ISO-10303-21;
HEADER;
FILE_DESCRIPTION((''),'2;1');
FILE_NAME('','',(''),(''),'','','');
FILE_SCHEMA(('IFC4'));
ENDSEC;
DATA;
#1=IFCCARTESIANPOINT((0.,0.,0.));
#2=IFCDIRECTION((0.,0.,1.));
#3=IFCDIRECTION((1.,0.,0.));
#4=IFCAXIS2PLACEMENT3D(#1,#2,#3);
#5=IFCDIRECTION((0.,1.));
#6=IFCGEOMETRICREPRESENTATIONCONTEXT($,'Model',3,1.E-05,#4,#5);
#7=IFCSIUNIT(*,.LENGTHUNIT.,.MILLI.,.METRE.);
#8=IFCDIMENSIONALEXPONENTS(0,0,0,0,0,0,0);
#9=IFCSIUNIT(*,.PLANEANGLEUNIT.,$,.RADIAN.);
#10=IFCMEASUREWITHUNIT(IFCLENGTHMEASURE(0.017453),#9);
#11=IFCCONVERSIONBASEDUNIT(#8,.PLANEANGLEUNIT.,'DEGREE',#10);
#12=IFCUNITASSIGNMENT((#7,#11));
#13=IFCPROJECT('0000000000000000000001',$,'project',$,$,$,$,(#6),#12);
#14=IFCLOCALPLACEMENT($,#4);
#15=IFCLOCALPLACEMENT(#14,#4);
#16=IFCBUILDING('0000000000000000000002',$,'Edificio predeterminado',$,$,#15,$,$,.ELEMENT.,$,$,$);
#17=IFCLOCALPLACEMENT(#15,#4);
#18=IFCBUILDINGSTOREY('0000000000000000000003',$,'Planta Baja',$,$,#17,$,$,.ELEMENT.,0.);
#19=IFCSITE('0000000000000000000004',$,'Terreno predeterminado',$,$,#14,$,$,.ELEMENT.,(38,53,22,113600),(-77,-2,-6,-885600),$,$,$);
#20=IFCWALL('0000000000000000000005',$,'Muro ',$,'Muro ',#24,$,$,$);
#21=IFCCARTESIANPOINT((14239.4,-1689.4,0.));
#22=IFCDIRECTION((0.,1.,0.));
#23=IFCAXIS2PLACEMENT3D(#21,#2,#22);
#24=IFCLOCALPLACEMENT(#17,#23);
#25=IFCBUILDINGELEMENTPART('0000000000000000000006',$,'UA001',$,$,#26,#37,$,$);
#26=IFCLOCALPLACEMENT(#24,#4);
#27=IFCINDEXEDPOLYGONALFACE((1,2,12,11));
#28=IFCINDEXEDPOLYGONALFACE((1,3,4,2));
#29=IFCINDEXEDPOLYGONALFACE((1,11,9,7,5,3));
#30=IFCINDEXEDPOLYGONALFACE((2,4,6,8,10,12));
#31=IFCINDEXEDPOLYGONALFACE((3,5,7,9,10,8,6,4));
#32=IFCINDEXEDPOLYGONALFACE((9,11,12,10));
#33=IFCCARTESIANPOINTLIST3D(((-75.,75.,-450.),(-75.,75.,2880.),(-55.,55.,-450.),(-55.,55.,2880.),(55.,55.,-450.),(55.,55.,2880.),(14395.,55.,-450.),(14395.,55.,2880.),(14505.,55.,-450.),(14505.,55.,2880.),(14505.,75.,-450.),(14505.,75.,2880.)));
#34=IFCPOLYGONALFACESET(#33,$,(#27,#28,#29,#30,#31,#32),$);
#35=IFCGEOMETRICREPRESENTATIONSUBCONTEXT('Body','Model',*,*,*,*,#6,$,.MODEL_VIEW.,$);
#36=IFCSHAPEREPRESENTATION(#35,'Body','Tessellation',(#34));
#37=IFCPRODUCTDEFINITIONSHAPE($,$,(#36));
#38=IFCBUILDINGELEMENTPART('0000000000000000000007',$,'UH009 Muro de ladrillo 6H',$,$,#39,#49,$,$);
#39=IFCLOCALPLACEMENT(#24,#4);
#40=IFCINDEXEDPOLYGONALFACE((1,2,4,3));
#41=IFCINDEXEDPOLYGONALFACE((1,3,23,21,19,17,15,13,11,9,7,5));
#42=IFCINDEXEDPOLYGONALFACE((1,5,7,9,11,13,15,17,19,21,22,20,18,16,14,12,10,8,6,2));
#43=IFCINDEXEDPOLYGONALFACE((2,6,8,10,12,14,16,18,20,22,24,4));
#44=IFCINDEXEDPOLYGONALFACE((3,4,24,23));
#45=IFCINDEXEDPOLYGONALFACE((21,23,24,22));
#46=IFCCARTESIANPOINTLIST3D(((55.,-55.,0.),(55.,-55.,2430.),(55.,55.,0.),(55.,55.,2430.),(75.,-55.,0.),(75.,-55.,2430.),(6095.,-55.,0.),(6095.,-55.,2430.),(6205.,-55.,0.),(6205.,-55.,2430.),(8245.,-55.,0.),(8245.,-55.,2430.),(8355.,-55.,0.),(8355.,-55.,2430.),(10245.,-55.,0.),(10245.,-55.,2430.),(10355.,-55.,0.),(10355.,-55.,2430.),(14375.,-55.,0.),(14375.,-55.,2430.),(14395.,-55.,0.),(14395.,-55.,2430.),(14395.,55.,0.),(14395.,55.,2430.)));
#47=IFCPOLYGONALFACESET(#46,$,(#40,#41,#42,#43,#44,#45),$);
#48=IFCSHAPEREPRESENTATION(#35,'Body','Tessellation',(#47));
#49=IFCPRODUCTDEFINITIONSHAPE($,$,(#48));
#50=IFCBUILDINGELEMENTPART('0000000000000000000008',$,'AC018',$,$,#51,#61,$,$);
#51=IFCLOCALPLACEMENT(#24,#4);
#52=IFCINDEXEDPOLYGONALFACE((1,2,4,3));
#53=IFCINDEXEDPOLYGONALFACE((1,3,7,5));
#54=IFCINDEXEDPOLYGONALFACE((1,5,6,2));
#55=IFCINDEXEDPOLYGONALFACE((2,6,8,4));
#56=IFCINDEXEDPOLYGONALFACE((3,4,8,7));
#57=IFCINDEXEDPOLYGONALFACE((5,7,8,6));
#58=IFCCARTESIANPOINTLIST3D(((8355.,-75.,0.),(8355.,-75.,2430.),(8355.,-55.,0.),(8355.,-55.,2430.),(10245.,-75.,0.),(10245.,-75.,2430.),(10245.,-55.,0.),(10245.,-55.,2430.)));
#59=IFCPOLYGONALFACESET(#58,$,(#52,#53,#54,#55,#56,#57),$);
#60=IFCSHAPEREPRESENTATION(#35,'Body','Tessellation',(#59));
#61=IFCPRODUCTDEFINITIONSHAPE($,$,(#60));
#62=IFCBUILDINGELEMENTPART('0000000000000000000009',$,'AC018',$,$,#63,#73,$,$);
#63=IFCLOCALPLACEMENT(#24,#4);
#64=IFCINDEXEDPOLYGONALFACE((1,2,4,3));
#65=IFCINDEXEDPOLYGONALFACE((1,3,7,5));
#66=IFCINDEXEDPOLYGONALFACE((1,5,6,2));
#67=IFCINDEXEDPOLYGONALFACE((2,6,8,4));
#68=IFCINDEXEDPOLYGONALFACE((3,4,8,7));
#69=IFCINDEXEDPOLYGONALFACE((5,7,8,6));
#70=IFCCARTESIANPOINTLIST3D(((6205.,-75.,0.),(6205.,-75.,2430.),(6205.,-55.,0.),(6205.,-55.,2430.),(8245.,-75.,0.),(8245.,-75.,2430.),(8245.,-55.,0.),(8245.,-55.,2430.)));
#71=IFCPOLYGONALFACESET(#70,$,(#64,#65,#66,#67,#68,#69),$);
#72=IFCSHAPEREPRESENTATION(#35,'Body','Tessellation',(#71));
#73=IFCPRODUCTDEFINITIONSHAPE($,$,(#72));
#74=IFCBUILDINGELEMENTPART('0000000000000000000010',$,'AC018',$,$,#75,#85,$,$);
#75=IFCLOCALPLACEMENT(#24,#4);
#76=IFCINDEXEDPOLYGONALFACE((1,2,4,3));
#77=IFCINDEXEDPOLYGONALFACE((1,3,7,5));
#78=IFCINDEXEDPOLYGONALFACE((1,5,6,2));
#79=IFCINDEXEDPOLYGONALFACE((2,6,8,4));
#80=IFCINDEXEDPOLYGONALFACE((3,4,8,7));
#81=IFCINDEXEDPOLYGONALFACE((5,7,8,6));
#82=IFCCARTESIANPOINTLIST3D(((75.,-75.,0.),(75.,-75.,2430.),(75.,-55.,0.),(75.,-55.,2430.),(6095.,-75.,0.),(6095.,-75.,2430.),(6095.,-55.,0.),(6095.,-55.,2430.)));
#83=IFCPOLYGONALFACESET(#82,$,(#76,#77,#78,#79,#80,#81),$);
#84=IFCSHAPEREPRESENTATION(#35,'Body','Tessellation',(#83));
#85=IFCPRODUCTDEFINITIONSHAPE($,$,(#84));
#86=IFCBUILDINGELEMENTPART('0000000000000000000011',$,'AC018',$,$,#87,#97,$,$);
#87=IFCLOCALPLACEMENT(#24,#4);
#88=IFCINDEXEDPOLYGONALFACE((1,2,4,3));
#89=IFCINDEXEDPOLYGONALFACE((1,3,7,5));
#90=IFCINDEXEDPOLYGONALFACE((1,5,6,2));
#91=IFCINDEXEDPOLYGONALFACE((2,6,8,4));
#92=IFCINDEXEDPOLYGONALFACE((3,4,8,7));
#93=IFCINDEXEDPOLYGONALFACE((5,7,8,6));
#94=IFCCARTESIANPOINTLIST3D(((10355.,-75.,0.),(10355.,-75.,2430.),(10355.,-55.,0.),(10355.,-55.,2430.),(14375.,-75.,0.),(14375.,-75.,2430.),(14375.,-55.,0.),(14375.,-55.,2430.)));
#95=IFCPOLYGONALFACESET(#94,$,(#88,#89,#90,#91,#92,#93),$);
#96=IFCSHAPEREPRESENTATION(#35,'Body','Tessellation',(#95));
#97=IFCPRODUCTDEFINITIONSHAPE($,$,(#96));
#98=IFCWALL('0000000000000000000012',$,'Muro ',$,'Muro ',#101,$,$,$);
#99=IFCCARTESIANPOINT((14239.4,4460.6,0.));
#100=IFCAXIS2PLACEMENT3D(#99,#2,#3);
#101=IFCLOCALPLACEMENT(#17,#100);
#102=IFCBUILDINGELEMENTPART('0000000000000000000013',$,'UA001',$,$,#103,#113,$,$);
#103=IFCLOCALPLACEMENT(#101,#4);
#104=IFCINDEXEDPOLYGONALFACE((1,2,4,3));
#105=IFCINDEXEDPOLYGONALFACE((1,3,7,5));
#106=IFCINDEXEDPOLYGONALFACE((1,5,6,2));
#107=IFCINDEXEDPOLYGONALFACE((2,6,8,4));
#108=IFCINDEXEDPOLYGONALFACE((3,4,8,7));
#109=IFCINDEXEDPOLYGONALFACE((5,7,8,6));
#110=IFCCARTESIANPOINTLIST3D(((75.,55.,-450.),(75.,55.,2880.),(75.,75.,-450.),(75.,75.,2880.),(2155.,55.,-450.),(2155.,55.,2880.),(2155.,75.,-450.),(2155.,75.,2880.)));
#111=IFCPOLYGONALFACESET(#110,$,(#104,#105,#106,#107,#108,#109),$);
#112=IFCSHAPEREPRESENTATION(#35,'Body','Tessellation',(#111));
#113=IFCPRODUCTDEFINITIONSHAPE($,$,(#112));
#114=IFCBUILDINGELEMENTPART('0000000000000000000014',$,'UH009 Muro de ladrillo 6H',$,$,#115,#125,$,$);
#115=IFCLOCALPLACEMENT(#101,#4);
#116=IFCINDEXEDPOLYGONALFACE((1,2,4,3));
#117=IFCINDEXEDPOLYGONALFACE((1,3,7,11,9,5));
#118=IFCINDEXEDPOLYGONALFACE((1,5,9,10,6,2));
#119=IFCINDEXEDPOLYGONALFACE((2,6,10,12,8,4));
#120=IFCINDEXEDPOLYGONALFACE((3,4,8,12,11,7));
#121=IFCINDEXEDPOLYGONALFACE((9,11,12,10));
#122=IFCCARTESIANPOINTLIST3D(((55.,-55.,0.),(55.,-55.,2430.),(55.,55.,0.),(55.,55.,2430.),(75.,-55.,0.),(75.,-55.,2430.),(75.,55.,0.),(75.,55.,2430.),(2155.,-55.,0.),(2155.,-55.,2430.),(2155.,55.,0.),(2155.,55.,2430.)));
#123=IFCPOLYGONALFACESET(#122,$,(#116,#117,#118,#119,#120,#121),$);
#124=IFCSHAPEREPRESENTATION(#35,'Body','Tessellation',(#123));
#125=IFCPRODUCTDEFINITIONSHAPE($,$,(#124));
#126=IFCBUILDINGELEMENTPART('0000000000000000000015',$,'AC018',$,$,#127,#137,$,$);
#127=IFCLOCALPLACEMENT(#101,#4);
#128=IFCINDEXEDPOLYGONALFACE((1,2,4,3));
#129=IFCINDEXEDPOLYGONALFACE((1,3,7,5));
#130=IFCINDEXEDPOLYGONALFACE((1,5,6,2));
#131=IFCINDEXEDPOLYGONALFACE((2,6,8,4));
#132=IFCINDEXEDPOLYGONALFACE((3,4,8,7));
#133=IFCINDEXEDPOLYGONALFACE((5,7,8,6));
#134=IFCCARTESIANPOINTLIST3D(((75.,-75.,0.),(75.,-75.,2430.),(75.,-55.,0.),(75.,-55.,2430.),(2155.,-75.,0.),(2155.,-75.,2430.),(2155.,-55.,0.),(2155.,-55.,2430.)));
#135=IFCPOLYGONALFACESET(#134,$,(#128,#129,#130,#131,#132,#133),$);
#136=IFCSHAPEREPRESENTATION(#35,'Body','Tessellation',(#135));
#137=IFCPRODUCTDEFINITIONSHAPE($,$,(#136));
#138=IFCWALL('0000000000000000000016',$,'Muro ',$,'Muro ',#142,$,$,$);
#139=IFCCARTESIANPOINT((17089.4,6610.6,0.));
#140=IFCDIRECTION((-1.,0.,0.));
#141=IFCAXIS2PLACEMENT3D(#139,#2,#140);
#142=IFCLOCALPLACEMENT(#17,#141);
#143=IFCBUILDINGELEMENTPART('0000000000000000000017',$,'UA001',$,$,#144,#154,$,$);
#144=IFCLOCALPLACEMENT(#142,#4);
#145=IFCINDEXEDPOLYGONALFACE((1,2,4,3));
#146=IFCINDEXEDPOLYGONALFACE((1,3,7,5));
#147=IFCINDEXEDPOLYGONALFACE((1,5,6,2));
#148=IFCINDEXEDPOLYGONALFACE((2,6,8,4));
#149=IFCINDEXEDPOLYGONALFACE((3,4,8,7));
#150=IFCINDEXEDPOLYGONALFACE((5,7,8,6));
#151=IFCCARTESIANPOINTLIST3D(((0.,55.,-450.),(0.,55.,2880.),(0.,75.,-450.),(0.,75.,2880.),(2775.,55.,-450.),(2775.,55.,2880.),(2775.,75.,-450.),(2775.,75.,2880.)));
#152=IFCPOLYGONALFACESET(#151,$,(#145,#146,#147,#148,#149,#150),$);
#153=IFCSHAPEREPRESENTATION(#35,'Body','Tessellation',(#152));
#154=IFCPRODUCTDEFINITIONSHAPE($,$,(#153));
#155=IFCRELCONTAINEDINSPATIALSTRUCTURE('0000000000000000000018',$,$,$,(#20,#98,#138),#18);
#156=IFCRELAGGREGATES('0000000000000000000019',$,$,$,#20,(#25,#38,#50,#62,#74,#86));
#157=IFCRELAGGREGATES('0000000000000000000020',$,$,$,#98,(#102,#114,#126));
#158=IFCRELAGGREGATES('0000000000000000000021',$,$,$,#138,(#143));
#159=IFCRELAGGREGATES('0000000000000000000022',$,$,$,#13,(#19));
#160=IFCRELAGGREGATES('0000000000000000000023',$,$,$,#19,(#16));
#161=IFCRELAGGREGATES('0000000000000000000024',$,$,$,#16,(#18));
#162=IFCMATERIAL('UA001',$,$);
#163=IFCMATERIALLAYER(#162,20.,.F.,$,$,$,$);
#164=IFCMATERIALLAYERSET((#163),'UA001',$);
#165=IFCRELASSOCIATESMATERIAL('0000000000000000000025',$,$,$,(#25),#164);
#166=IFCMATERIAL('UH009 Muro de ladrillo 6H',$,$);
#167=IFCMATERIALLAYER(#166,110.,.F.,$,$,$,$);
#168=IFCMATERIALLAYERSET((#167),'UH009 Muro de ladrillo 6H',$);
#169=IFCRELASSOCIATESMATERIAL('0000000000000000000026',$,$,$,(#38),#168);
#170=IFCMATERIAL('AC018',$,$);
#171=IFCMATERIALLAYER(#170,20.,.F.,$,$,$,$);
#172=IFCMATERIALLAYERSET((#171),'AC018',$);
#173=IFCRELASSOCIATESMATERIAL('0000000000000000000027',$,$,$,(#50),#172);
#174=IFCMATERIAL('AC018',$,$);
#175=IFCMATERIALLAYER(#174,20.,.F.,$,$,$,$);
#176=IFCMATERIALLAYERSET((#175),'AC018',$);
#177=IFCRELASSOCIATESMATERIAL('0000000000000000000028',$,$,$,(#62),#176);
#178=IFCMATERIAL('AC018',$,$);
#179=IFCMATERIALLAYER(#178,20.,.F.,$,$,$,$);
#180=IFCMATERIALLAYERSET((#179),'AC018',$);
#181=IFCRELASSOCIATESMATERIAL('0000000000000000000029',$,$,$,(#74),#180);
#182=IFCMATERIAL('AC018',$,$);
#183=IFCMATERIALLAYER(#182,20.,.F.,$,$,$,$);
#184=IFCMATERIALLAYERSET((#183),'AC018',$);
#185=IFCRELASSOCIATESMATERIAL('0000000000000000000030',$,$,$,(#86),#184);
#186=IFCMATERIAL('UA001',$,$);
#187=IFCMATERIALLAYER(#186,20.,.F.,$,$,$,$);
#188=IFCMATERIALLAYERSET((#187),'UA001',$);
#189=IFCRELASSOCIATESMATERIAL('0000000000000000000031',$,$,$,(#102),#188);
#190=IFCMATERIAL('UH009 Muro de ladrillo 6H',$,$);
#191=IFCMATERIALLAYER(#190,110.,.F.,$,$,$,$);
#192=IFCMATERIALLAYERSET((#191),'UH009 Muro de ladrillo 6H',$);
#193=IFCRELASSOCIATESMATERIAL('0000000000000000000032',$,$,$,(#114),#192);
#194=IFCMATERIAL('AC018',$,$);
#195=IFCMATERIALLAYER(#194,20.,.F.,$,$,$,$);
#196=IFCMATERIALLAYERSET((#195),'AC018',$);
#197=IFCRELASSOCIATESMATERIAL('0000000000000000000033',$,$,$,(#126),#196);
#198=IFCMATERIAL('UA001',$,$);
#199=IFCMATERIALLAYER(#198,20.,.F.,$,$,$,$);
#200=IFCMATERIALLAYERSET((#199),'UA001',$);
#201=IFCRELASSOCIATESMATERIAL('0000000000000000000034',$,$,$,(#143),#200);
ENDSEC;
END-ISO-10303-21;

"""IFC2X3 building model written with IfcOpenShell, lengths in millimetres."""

from ifc_helpers import new_model, entity, si_unit, converted_unit, direction, frame, origin_with_axes, place, context, subcontext, project, spatial, polyline, outline, extrude, material, layer, layer_set, layer_usage, element, aggregate, save


model = new_model("IFC2X3")

# Units and contexts
model_context = context("Model", 3, precision=1e-05, world=origin_with_axes(), true_north=direction((0.0, 1.0)))
body_context = subcontext(model_context, "Body", "Model", "MODEL_VIEW")
ifc_project = project(units=[si_unit("LENGTHUNIT", "METRE", prefix="MILLI"), converted_unit("PLANEANGLEUNIT", "DEGREE", entity("IfcLengthMeasure", 0.017453), si_unit("PLANEANGLEUNIT", "RADIAN"), dimensions=[0, 0, 0, 0, 0, 0, 0])], contexts=[model_context])

# Site, building, storey
site_placement = place(None, origin_with_axes())
site = spatial("IfcSite", under=ifc_project, at=site_placement, Name="Terreno predeterminado", CompositionType="ELEMENT", RefLatitude=(38, 53, 22, 113600), RefLongitude=(-77, -2, -6, -885600))
building_placement = place(site_placement, origin_with_axes())
building = spatial("IfcBuilding", under=site, at=building_placement, Name="Edificio predeterminado", CompositionType="ELEMENT")
storey_placement = place(building_placement, origin_with_axes())
storey = spatial("IfcBuildingStorey", under=building, at=storey_placement, Name="Planta Baja", CompositionType="ELEMENT", Elevation=0.0)

# Walls, building element parts
wall_1_placement = place(storey_placement, frame((14239.4, -1689.4, 0.0), z_axis=(0.0, 0.0, 1.0), x_axis=(0.0, 1.0, 0.0)))
wall_1 = element("IfcWall", 1, at=wall_1_placement, inside=storey, Name="Muro ", ObjectType="Muro ")
ifc_material_1 = material(Name="UA001")
ifc_layer_1 = layer(ifc_material_1, 20.0, ventilated=False)
ifc_layer_set_1 = layer_set([ifc_layer_1], Name="UA001")
ifc_layer_usage_1 = layer_usage(ifc_layer_set_1, "AXIS2", "NEGATIVE", -75.0)
building_element_part_1_placement = place(wall_1_placement, origin_with_axes())
building_element_part_1 = element("IfcBuildingElementPart", 2, at=building_element_part_1_placement, material=ifc_layer_usage_1, Name="UA001", context=body_context, shape_type="SweptSolid", body=[
    extrude(outline(polyline([(14505.0, 75.0), (14505.0, 55.0), (14395.0, 55.0), (55.0, 55.0), (-55.0, 55.0), (-75.0, 75.0), (14505.0, 75.0)])), frame((0.0, 0.0, -450.0), z_axis=(0.0, 0.0, 1.0), x_axis=(1.0, 0.0, 0.0)), (0.0, 0.0, 1.0), 3330.0),
])
ifc_material_2 = material(Name="UH009 Muro de ladrillo 6H")
ifc_layer_2 = layer(ifc_material_2, 110.0, ventilated=False)
ifc_layer_set_2 = layer_set([ifc_layer_2], Name="UH009 Muro de ladrillo 6H")
ifc_layer_usage_2 = layer_usage(ifc_layer_set_2, "AXIS2", "NEGATIVE", -55.0)
building_element_part_2_placement = place(wall_1_placement, origin_with_axes())
building_element_part_2 = element("IfcBuildingElementPart", 3, at=building_element_part_2_placement, material=ifc_layer_usage_2, Name="UH009 Muro de ladrillo 6H", context=body_context, shape_type="SweptSolid", body=[
    extrude(outline(polyline([(14395.0, 55.0), (14395.0, -55.0), (14375.0, -55.0), (10355.0, -55.0), (10245.0, -55.0), (8355.0, -55.0), (8245.0, -55.0), (6205.0, -55.0), (6095.0, -55.0), (75.0, -55.0), (55.0, -55.0), (55.0, 55.0), (14395.0, 55.0)])), origin_with_axes(), (0.0, 0.0, 1.0), 2430.0),
])
ifc_material_3 = material(Name="AC018")
ifc_layer_3 = layer(ifc_material_3, 20.0, ventilated=False)
ifc_layer_set_3 = layer_set([ifc_layer_3], Name="AC018")
ifc_layer_usage_3 = layer_usage(ifc_layer_set_3, "AXIS2", "NEGATIVE", 55.0)
building_element_part_3_placement = place(wall_1_placement, origin_with_axes())
building_element_part_3 = element("IfcBuildingElementPart", 4, at=building_element_part_3_placement, material=ifc_layer_usage_3, Name="AC018", context=body_context, shape_type="SweptSolid", body=[
    extrude(outline(polyline([(8355.0, -55.0), (10245.0, -55.0), (10245.0, -75.0), (8355.0, -75.0), (8355.0, -55.0)])), origin_with_axes(), (0.0, 0.0, 1.0), 2430.0),
])
ifc_material_4 = material(Name="AC018")
ifc_layer_4 = layer(ifc_material_4, 20.0, ventilated=False)
ifc_layer_set_4 = layer_set([ifc_layer_4], Name="AC018")
ifc_layer_usage_4 = layer_usage(ifc_layer_set_4, "AXIS2", "NEGATIVE", 55.0)
building_element_part_4_placement = place(wall_1_placement, origin_with_axes())
building_element_part_4 = element("IfcBuildingElementPart", 5, at=building_element_part_4_placement, material=ifc_layer_usage_4, Name="AC018", context=body_context, shape_type="SweptSolid", body=[
    extrude(outline(polyline([(8245.0, -55.0), (8245.0, -75.0), (6205.0, -75.0), (6205.0, -55.0), (8245.0, -55.0)])), origin_with_axes(), (0.0, 0.0, 1.0), 2430.0),
])
ifc_material_5 = material(Name="AC018")
ifc_layer_5 = layer(ifc_material_5, 20.0, ventilated=False)
ifc_layer_set_5 = layer_set([ifc_layer_5], Name="AC018")
ifc_layer_usage_5 = layer_usage(ifc_layer_set_5, "AXIS2", "NEGATIVE", 55.0)
building_element_part_5_placement = place(wall_1_placement, origin_with_axes())
building_element_part_5 = element("IfcBuildingElementPart", 6, at=building_element_part_5_placement, material=ifc_layer_usage_5, Name="AC018", context=body_context, shape_type="SweptSolid", body=[
    extrude(outline(polyline([(6095.0, -55.0), (6095.0, -75.0), (75.0, -75.0), (75.0, -55.0), (6095.0, -55.0)])), origin_with_axes(), (0.0, 0.0, 1.0), 2430.0),
])
ifc_material_6 = material(Name="AC018")
ifc_layer_6 = layer(ifc_material_6, 20.0, ventilated=False)
ifc_layer_set_6 = layer_set([ifc_layer_6], Name="AC018")
ifc_layer_usage_6 = layer_usage(ifc_layer_set_6, "AXIS2", "NEGATIVE", 55.0)
building_element_part_6_placement = place(wall_1_placement, origin_with_axes())
building_element_part_6 = element("IfcBuildingElementPart", 7, at=building_element_part_6_placement, material=ifc_layer_usage_6, Name="AC018", context=body_context, shape_type="SweptSolid", body=[
    extrude(outline(polyline([(14375.0, -55.0), (14375.0, -75.0), (10355.0, -75.0), (10355.0, -55.0), (14375.0, -55.0)])), origin_with_axes(), (0.0, 0.0, 1.0), 2430.0),
])
aggregate(wall_1, [building_element_part_1, building_element_part_2, building_element_part_3, building_element_part_4, building_element_part_5, building_element_part_6])
wall_2_placement = place(storey_placement, frame((14239.4, 4460.6, 0.0), z_axis=(0.0, 0.0, 1.0), x_axis=(1.0, 0.0, 0.0)))
wall_2 = element("IfcWall", 8, at=wall_2_placement, inside=storey, Name="Muro ", ObjectType="Muro ")
ifc_material_7 = material(Name="UA001")
ifc_layer_7 = layer(ifc_material_7, 20.0, ventilated=False)
ifc_layer_set_7 = layer_set([ifc_layer_7], Name="UA001")
ifc_layer_usage_7 = layer_usage(ifc_layer_set_7, "AXIS2", "NEGATIVE", -75.0)
building_element_part_7_placement = place(wall_2_placement, origin_with_axes())
building_element_part_7 = element("IfcBuildingElementPart", 9, at=building_element_part_7_placement, material=ifc_layer_usage_7, Name="UA001", context=body_context, shape_type="SweptSolid", body=[
    extrude(outline(polyline([(2155.0, 75.0), (2155.0, 55.0), (75.0, 55.0), (75.0, 75.0), (2155.0, 75.0)])), frame((0.0, 0.0, -450.0), z_axis=(0.0, 0.0, 1.0), x_axis=(1.0, 0.0, 0.0)), (0.0, 0.0, 1.0), 3330.0),
])
ifc_material_8 = material(Name="UH009 Muro de ladrillo 6H")
ifc_layer_8 = layer(ifc_material_8, 110.0, ventilated=False)
ifc_layer_set_8 = layer_set([ifc_layer_8], Name="UH009 Muro de ladrillo 6H")
ifc_layer_usage_8 = layer_usage(ifc_layer_set_8, "AXIS2", "NEGATIVE", -55.0)
building_element_part_8_placement = place(wall_2_placement, origin_with_axes())
building_element_part_8 = element("IfcBuildingElementPart", 10, at=building_element_part_8_placement, material=ifc_layer_usage_8, Name="UH009 Muro de ladrillo 6H", context=body_context, shape_type="SweptSolid", body=[
    extrude(outline(polyline([(2155.0, 55.0), (2155.0, -55.0), (75.0, -55.0), (55.0, -55.0), (55.0, 55.0), (75.0, 55.0), (2155.0, 55.0)])), origin_with_axes(), (0.0, 0.0, 1.0), 2430.0),
])
ifc_material_9 = material(Name="AC018")
ifc_layer_9 = layer(ifc_material_9, 20.0, ventilated=False)
ifc_layer_set_9 = layer_set([ifc_layer_9], Name="AC018")
ifc_layer_usage_9 = layer_usage(ifc_layer_set_9, "AXIS2", "NEGATIVE", 55.0)
building_element_part_9_placement = place(wall_2_placement, origin_with_axes())
building_element_part_9 = element("IfcBuildingElementPart", 11, at=building_element_part_9_placement, material=ifc_layer_usage_9, Name="AC018", context=body_context, shape_type="SweptSolid", body=[
    extrude(outline(polyline([(2155.0, -55.0), (2155.0, -75.0), (75.0, -75.0), (75.0, -55.0), (2155.0, -55.0)])), origin_with_axes(), (0.0, 0.0, 1.0), 2430.0),
])
aggregate(wall_2, [building_element_part_7, building_element_part_8, building_element_part_9])

# Wall, building element part
wall_3_placement = place(storey_placement, frame((17089.4, 6610.6, 0.0), z_axis=(0.0, 0.0, 1.0), x_axis=(-1.0, 0.0, 0.0)))
wall_3 = element("IfcWall", 12, at=wall_3_placement, inside=storey, Name="Muro ", ObjectType="Muro ")
ifc_material_10 = material(Name="UA001")
ifc_layer_10 = layer(ifc_material_10, 20.0, ventilated=False)
ifc_layer_set_10 = layer_set([ifc_layer_10], Name="UA001")
ifc_layer_usage_10 = layer_usage(ifc_layer_set_10, "AXIS2", "NEGATIVE", -75.0)
building_element_part_10_placement = place(wall_3_placement, origin_with_axes())
building_element_part_10 = element("IfcBuildingElementPart", 13, at=building_element_part_10_placement, material=ifc_layer_usage_10, Name="UA001", context=body_context, shape_type="SweptSolid", body=[
    extrude(outline(polyline([(0.0, 75.0), (2775.0, 75.0), (2775.0, 55.0), (0.0, 55.0), (0.0, 75.0)])), frame((0.0, 0.0, -450.0), z_axis=(0.0, 0.0, 1.0), x_axis=(1.0, 0.0, 0.0)), (0.0, 0.0, 1.0), 3330.0),
])
aggregate(wall_3, [building_element_part_10])

save(model, "model.ifc")
